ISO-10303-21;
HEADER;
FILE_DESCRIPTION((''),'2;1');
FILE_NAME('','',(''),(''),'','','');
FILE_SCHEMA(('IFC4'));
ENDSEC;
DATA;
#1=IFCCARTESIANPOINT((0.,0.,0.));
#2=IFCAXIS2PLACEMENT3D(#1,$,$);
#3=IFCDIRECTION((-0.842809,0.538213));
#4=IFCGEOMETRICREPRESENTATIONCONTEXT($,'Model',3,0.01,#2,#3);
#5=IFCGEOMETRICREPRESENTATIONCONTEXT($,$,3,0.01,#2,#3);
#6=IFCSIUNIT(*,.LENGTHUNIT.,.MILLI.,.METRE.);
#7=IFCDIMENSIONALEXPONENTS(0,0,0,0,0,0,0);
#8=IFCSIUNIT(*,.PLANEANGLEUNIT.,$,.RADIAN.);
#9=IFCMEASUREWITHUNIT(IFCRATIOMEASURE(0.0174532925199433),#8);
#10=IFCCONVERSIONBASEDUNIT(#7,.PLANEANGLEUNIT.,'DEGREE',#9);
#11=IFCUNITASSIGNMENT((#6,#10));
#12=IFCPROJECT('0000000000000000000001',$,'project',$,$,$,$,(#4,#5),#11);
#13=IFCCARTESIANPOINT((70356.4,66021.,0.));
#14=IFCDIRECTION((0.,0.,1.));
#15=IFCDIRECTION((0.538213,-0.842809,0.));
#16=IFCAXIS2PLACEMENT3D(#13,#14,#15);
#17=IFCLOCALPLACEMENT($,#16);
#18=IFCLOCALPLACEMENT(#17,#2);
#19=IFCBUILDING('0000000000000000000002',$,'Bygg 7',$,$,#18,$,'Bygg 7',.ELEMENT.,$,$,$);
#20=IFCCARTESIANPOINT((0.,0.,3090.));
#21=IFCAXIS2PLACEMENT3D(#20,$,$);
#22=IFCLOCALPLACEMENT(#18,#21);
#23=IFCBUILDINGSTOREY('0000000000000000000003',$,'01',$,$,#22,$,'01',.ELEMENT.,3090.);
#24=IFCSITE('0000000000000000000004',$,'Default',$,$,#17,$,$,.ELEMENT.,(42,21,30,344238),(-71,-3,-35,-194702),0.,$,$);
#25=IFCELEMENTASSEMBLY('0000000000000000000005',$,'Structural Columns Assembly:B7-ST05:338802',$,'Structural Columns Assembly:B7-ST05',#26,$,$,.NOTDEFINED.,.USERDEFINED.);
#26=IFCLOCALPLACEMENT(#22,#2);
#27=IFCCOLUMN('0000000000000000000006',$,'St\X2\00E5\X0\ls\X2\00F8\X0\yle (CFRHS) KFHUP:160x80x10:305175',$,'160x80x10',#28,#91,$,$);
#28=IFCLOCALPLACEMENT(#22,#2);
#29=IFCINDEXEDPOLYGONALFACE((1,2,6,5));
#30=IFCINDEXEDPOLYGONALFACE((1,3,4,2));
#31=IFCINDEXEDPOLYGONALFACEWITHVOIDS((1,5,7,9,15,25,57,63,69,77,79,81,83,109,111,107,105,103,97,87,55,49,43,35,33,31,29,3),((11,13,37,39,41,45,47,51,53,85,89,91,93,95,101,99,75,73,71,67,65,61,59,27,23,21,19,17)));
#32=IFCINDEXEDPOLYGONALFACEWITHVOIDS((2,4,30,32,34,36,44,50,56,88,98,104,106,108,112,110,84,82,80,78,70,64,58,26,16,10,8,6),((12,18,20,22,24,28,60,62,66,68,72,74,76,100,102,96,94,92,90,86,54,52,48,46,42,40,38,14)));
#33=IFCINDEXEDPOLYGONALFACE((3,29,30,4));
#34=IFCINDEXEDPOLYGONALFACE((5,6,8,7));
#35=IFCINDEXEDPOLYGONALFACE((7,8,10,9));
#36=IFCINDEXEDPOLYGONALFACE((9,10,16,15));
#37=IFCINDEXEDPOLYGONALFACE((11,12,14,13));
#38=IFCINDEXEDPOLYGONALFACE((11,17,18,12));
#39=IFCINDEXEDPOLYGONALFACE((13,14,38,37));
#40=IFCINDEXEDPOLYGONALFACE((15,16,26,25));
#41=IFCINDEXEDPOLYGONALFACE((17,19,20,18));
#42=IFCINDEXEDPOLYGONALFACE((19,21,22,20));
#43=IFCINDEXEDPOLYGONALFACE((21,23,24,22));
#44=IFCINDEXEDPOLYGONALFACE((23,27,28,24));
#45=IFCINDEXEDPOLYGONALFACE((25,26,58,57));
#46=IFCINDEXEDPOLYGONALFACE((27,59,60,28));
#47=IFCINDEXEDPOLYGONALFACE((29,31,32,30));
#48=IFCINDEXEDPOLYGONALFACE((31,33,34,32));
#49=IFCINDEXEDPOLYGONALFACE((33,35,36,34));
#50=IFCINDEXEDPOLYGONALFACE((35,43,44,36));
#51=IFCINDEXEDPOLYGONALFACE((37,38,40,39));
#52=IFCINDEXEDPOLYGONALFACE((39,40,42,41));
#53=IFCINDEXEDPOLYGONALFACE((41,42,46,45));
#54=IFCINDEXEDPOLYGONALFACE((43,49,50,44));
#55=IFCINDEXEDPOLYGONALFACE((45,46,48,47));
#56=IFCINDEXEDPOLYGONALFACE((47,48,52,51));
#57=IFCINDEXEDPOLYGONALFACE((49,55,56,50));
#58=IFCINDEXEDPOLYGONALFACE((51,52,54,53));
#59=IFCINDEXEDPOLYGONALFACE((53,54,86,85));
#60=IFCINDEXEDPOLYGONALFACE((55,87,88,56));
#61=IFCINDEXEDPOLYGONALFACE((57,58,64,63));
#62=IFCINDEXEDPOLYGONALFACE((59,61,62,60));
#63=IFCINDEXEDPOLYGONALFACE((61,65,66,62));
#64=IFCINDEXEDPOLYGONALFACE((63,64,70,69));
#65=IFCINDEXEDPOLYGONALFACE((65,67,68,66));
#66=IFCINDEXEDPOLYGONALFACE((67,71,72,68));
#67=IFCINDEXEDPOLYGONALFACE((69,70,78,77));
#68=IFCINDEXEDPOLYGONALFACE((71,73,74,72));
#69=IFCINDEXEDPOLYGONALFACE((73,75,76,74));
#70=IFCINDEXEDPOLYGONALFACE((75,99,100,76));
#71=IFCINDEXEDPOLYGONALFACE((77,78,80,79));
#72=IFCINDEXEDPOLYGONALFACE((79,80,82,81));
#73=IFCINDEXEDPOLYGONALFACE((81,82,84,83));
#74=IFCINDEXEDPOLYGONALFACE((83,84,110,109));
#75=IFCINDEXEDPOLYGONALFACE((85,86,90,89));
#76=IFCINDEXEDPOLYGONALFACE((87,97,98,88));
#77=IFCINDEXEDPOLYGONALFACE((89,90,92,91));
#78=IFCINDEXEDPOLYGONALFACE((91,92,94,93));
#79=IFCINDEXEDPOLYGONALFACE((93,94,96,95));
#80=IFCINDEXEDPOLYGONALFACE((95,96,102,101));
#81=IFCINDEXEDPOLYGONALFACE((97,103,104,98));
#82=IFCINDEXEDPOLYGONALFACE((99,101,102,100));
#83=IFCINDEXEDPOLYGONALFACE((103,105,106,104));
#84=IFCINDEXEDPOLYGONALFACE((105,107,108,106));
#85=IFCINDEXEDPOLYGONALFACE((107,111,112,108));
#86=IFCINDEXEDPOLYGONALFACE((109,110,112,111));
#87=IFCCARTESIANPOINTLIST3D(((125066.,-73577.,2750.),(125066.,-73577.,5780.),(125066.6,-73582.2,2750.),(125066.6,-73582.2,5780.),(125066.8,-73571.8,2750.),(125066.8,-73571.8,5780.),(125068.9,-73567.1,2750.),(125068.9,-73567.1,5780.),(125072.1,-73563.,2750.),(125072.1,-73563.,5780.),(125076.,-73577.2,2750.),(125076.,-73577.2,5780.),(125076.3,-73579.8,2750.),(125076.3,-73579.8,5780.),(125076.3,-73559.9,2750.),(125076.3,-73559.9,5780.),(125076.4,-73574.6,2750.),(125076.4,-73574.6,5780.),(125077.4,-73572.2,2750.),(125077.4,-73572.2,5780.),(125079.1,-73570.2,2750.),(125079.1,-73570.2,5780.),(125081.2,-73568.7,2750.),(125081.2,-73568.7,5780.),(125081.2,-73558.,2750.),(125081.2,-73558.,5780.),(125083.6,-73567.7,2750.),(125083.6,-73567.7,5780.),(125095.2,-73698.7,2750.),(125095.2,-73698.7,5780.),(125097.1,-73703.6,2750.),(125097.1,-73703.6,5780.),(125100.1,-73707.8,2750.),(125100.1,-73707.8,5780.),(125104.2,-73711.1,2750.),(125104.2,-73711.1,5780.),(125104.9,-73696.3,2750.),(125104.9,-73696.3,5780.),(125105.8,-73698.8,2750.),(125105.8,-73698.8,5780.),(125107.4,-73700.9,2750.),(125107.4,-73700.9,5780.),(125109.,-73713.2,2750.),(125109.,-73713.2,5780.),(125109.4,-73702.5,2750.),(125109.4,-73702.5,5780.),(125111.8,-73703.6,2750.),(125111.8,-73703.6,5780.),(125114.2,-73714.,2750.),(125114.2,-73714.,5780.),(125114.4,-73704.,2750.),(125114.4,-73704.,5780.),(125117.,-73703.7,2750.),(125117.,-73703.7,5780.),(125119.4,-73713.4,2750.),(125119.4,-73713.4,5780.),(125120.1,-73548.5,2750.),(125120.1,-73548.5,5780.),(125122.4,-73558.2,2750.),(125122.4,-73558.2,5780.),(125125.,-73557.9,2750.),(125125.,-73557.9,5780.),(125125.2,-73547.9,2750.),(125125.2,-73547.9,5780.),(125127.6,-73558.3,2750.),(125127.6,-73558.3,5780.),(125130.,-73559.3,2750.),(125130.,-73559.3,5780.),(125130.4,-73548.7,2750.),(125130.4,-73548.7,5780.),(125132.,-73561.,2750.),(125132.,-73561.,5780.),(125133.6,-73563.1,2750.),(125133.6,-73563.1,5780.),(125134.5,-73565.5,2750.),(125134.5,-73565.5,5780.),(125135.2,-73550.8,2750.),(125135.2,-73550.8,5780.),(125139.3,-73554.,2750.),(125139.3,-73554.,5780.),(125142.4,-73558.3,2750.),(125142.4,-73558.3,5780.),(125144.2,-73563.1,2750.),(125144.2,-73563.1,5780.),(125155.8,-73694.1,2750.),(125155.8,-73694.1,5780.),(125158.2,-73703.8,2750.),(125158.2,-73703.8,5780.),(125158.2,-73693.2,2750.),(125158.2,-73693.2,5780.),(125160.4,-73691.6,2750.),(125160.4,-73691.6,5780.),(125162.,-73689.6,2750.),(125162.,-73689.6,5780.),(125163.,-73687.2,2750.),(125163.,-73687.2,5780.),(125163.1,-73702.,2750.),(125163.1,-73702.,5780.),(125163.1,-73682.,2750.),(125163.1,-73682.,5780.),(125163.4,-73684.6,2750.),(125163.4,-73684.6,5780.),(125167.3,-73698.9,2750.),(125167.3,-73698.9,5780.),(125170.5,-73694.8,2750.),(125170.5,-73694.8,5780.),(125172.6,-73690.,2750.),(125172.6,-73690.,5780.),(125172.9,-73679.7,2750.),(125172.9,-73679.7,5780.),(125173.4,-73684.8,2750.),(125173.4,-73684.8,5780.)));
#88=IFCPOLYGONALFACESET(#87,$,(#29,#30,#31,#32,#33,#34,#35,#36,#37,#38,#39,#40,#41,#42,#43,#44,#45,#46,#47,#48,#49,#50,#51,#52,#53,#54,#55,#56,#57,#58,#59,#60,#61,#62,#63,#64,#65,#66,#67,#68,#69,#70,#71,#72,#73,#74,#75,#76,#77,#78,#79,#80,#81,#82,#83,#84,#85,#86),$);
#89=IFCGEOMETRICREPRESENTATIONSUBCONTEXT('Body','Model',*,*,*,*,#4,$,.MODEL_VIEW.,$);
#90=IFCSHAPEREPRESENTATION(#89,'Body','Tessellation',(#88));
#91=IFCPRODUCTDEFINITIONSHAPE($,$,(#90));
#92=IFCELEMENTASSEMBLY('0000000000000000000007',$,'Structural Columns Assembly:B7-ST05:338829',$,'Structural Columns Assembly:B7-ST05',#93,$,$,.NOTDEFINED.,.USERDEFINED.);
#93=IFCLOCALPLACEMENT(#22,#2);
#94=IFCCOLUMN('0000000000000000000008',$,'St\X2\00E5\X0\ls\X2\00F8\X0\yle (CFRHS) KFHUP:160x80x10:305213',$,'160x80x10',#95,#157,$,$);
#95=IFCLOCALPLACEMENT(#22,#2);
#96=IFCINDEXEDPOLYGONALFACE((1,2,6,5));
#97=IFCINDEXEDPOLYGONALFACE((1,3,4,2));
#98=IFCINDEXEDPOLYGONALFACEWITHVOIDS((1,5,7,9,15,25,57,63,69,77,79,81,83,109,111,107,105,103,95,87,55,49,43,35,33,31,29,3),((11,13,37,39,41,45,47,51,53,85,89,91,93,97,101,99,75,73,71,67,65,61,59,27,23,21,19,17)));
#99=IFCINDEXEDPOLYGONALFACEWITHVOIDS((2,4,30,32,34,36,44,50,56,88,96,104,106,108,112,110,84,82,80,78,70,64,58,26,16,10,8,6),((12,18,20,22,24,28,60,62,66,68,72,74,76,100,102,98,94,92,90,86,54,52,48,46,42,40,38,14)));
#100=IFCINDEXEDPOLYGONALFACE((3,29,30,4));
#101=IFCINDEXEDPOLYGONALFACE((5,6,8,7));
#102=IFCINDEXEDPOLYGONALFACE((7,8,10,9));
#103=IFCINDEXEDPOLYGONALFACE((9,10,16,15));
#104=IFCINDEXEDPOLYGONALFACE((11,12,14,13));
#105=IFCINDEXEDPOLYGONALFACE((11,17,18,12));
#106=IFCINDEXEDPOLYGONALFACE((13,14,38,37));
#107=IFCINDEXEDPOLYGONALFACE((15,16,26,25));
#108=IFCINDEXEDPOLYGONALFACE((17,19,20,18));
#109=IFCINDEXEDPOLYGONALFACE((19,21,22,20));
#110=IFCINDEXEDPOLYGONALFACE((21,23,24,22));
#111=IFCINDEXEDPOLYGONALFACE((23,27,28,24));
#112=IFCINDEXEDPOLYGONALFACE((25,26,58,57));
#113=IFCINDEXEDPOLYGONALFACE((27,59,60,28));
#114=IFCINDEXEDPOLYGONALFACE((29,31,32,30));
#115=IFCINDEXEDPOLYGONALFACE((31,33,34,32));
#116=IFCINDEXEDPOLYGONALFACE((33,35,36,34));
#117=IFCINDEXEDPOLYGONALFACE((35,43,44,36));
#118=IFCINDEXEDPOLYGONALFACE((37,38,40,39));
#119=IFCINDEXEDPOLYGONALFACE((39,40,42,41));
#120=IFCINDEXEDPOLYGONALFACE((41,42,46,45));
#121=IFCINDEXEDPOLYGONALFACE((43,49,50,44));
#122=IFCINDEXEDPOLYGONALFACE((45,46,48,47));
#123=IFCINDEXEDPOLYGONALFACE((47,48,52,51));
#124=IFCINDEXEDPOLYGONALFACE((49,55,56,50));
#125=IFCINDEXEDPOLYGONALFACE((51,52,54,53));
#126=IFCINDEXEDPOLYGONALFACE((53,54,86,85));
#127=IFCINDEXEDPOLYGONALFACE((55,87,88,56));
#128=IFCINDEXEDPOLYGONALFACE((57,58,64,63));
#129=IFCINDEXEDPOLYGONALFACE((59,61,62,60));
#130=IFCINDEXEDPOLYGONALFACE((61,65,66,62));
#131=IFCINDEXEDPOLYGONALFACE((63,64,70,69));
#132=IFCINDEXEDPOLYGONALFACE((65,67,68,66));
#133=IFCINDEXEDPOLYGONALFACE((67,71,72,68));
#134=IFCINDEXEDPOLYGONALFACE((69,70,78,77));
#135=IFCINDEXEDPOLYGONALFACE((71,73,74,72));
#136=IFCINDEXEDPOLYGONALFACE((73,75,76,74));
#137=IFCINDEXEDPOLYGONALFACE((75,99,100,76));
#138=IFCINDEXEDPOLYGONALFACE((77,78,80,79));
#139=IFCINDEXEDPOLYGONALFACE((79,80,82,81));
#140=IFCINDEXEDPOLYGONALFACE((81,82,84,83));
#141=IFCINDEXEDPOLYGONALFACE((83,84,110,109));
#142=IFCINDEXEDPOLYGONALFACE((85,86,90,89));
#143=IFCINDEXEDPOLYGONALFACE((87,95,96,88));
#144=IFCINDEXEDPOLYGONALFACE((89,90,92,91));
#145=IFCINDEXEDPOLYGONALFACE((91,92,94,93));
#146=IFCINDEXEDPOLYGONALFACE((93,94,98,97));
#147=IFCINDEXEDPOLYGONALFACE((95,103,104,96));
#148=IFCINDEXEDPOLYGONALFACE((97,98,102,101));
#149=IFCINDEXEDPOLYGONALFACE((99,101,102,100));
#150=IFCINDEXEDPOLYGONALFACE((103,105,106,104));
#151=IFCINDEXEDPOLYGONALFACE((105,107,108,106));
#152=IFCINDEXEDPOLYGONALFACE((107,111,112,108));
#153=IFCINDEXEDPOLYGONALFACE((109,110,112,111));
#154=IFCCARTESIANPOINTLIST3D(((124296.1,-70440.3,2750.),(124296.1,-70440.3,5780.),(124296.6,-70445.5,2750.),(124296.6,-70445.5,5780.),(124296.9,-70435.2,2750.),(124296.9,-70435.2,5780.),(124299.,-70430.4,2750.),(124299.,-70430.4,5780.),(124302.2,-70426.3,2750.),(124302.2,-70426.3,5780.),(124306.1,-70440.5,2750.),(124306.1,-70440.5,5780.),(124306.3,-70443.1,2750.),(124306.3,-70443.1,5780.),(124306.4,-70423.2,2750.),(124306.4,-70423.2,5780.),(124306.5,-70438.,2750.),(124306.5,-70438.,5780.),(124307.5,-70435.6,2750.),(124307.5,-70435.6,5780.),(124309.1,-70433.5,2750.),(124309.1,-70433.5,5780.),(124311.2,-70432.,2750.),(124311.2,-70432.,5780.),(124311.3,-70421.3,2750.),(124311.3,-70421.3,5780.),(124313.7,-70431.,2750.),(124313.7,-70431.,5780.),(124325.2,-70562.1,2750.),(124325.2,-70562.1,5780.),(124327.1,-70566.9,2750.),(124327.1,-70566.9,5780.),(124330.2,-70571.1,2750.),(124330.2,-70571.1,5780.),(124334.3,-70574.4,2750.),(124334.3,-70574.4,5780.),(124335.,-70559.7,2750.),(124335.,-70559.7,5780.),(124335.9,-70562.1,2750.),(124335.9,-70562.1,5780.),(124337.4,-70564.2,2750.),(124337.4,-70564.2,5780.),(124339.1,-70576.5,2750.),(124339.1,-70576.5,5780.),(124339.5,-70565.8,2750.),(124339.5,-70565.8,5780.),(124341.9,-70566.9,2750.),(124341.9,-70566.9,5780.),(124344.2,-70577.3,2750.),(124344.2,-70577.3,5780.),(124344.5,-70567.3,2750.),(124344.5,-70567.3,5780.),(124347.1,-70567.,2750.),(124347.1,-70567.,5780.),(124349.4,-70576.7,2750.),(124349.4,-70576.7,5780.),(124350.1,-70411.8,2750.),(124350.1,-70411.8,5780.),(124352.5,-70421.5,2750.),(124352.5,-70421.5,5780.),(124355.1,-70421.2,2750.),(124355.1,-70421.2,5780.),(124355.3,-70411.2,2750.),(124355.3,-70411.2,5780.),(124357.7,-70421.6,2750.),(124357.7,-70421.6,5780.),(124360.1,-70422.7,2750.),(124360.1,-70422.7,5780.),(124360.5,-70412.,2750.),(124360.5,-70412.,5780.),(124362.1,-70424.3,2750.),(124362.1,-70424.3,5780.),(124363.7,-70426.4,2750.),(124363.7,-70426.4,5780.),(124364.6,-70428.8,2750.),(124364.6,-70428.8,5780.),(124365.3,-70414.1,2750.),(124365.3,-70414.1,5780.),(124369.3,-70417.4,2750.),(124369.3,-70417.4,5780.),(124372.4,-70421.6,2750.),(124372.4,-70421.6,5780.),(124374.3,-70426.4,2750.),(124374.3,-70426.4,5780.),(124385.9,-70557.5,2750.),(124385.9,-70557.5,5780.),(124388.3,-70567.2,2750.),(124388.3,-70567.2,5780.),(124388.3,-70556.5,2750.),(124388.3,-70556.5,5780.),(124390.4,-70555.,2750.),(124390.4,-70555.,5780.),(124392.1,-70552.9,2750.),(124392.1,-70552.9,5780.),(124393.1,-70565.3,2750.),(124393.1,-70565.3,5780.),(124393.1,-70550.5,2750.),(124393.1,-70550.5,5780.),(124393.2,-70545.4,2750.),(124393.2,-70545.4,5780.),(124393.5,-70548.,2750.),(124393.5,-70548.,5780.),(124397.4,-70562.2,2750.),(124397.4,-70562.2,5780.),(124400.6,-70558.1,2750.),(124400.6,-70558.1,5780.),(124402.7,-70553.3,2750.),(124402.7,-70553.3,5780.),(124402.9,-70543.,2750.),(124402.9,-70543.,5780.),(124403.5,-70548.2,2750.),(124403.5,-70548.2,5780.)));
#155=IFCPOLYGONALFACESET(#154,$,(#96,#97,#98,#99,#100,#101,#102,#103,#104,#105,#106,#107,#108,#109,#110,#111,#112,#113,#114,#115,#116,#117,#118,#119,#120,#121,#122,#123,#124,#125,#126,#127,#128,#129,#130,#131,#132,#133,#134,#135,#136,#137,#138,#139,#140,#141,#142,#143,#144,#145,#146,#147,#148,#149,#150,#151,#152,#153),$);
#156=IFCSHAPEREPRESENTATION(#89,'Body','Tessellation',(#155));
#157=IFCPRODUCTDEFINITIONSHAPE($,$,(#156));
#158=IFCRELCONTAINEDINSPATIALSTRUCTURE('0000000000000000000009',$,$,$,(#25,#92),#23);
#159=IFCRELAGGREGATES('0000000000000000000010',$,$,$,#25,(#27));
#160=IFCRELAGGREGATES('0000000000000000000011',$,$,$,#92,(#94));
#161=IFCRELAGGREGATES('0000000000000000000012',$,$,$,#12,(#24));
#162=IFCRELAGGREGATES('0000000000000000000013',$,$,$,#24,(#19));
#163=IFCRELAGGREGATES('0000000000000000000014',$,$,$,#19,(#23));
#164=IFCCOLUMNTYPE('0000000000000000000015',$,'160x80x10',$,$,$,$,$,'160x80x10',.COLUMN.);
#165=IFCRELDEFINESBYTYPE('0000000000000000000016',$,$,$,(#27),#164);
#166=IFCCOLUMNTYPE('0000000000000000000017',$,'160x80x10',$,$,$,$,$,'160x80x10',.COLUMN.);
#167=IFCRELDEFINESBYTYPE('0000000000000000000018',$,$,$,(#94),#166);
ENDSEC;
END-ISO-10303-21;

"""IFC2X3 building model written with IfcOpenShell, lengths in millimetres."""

from ifc_helpers import new_model, entity, si_unit, converted_unit, direction, frame, frame_2d, origin, place, context, subcontext, project, spatial, polyline, circle_curve, parameter, trimmed, segment, composite_curve, outline, extrude, source, transform, mapped, type_object, type_shapes, element, aggregate, save


model = new_model("IFC2X3")

# Units and contexts
model_context = context("Model", 3, precision=0.01, world=origin(), true_north=direction((-0.842809, 0.538213)))
context_of_model = context(None, 3, precision=0.01, world=origin(), true_north=direction((-0.842809, 0.538213)))
body_context = subcontext(model_context, "Body", "Model", "MODEL_VIEW")
ifc_project = project(units=[si_unit("LENGTHUNIT", "METRE", prefix="MILLI"), converted_unit("PLANEANGLEUNIT", "DEGREE", entity("IfcRatioMeasure", 0.0174532925199433), si_unit("PLANEANGLEUNIT", "RADIAN"), dimensions=[0, 0, 0, 0, 0, 0, 0])], contexts=[model_context, context_of_model])

# Site, building, storey
site_placement = place(None, frame((70356.4, 66021.0, 0.0), z_axis=(0.0, 0.0, 1.0), x_axis=(0.538213, -0.842809, 0.0)))
site = spatial("IfcSite", under=ifc_project, at=site_placement, Name="Default", CompositionType="ELEMENT", RefLatitude=(42, 21, 30, 344238), RefLongitude=(-71, -3, -35, -194702), RefElevation=0.0)
building_placement = place(site_placement, origin())
building = spatial("IfcBuilding", under=site, at=building_placement, Name="Bygg 7", LongName="Bygg 7", CompositionType="ELEMENT")
storey_placement = place(building_placement, frame((0.0, 0.0, 3090.0)))
storey = spatial("IfcBuildingStorey", under=building, at=storey_placement, Name="01", LongName="01", CompositionType="ELEMENT", Elevation=3090.0)

# Element assemblies, columns
assembly_1_placement = place(storey_placement, origin())
assembly_1 = element("IfcElementAssembly", 1, at=assembly_1_placement, inside=storey, Name="Structural Columns Assembly:B7-ST05:338802", ObjectType="Structural Columns Assembly:B7-ST05", AssemblyPlace="NOTDEFINED", PredefinedType="USERDEFINED")
column_type_1 = type_object("IfcColumnType", Name="160x80x10", ElementType="160x80x10", PredefinedType="COLUMN")
shared_shape_1 = source(origin(), body_context, "Body", "SweptSolid", [
    extrude(outline(composite_curve([segment(trimmed(circle_curve(frame_2d((-20.0, 60.0), x_axis=(1.0, 0.0)), 20.0), [parameter(90.0)], [parameter(180.0)], True, "PARAMETER"), True, "CONTINUOUS"), segment(polyline([(-40.0, 60.0), (-40.0, -60.0)]), True, "CONTINUOUS"), segment(trimmed(circle_curve(frame_2d((-20.0, -60.0), x_axis=(1.0, 0.0)), 20.0), [parameter(180.0)], [parameter(270.0)], True, "PARAMETER"), True, "CONTINUOUS"), segment(polyline([(-20.0, -80.0), (20.0, -80.0)]), True, "CONTINUOUS"), segment(trimmed(circle_curve(frame_2d((20.0, -60.0), x_axis=(1.0, 0.0)), 20.0), [parameter(270.0)], [parameter(0.0)], True, "PARAMETER"), True, "CONTINUOUS"), segment(polyline([(40.0, -60.0), (40.0, 60.0)]), True, "CONTINUOUS"), segment(trimmed(circle_curve(frame_2d((20.0, 60.0), x_axis=(1.0, 0.0)), 20.0), [parameter(0.0)], [parameter(90.0)], True, "PARAMETER"), True, "CONTINUOUS"), segment(polyline([(20.0, 80.0), (-20.0, 80.0)]), True, "CONTINUOUS")], self_intersect=False), holes=[composite_curve([segment(polyline([(-20.0, 70.0), (20.0, 70.0)]), True, "CONTINUOUS"), segment(trimmed(circle_curve(frame_2d((20.0, 60.0), x_axis=(1.0, 0.0)), 10.0), [parameter(360.0)], [parameter(90.0)], True, "PARAMETER"), False, "CONTINUOUS"), segment(polyline([(30.0, 60.0), (30.0, -60.0)]), True, "CONTINUOUS"), segment(trimmed(circle_curve(frame_2d((20.0, -60.0), x_axis=(1.0, 0.0)), 10.0), [parameter(270.0)], [parameter(360.0)], True, "PARAMETER"), False, "CONTINUOUS"), segment(polyline([(20.0, -70.0), (-20.0, -70.0)]), True, "CONTINUOUS"), segment(trimmed(circle_curve(frame_2d((-20.0, -60.0), x_axis=(1.0, 0.0)), 10.0), [parameter(180.0)], [parameter(270.0)], True, "PARAMETER"), False, "CONTINUOUS"), segment(polyline([(-30.0, -60.0), (-30.0, 60.0)]), True, "CONTINUOUS"), segment(trimmed(circle_curve(frame_2d((-20.0, 60.0), x_axis=(1.0, 0.0)), 10.0), [parameter(90.0)], [parameter(180.0)], True, "PARAMETER"), False, "CONTINUOUS")], self_intersect=False)]), frame((55.3, 84.6, 0.0), z_axis=(0.0, 0.0, 1.0), x_axis=(-0.971172, -0.238381, 0.0)), (0.0, 0.0, 1.0), 3030.0),
])
type_shapes(column_type_1, [shared_shape_1])
column_1_placement = place(assembly_1_placement, frame((125064.4, -73715.5, 2750.0)))
column_1 = element("IfcColumn", 2, at=column_1_placement, type_object=column_type_1, Name="Stålsøyle (CFRHS) KFHUP:160x80x10:305175", ObjectType="160x80x10", context=body_context, shape_type="MappedRepresentation", body=[
    mapped(shared_shape_1, transform((0.0, 0.0, 0.0), scale=1.0)),
])
aggregate(assembly_1, [column_1])
assembly_2_placement = place(storey_placement, origin())
assembly_2 = element("IfcElementAssembly", 3, at=assembly_2_placement, inside=storey, Name="Structural Columns Assembly:B7-ST05:338829", ObjectType="Structural Columns Assembly:B7-ST05", AssemblyPlace="NOTDEFINED", PredefinedType="USERDEFINED")
column_type_2 = type_object("IfcColumnType", Name="160x80x10", ElementType="160x80x10", PredefinedType="COLUMN")
shared_shape_2 = source(origin(), body_context, "Body", "SweptSolid", [
    extrude(outline(composite_curve([segment(trimmed(circle_curve(frame_2d((-20.0, 60.0), x_axis=(1.0, 0.0)), 20.0), [parameter(90.0)], [parameter(180.0)], True, "PARAMETER"), True, "CONTINUOUS"), segment(polyline([(-40.0, 60.0), (-40.0, -60.0)]), True, "CONTINUOUS"), segment(trimmed(circle_curve(frame_2d((-20.0, -60.0), x_axis=(1.0, 0.0)), 20.0), [parameter(180.0)], [parameter(270.0)], True, "PARAMETER"), True, "CONTINUOUS"), segment(polyline([(-20.0, -80.0), (20.0, -80.0)]), True, "CONTINUOUS"), segment(trimmed(circle_curve(frame_2d((20.0, -60.0), x_axis=(1.0, 0.0)), 20.0), [parameter(270.0)], [parameter(0.0)], True, "PARAMETER"), True, "CONTINUOUS"), segment(polyline([(40.0, -60.0), (40.0, 60.0)]), True, "CONTINUOUS"), segment(trimmed(circle_curve(frame_2d((20.0, 60.0), x_axis=(1.0, 0.0)), 20.0), [parameter(0.0)], [parameter(90.0)], True, "PARAMETER"), True, "CONTINUOUS"), segment(polyline([(20.0, 80.0), (-20.0, 80.0)]), True, "CONTINUOUS")], self_intersect=False), holes=[composite_curve([segment(polyline([(-20.0, 70.0), (20.0, 70.0)]), True, "CONTINUOUS"), segment(trimmed(circle_curve(frame_2d((20.0, 60.0), x_axis=(1.0, 0.0)), 10.0), [parameter(360.0)], [parameter(90.0)], True, "PARAMETER"), False, "CONTINUOUS"), segment(polyline([(30.0, 60.0), (30.0, -60.0)]), True, "CONTINUOUS"), segment(trimmed(circle_curve(frame_2d((20.0, -60.0), x_axis=(1.0, 0.0)), 10.0), [parameter(270.0)], [parameter(360.0)], True, "PARAMETER"), False, "CONTINUOUS"), segment(polyline([(20.0, -70.0), (-20.0, -70.0)]), True, "CONTINUOUS"), segment(trimmed(circle_curve(frame_2d((-20.0, -60.0), x_axis=(1.0, 0.0)), 10.0), [parameter(180.0)], [parameter(270.0)], True, "PARAMETER"), False, "CONTINUOUS"), segment(polyline([(-30.0, -60.0), (-30.0, 60.0)]), True, "CONTINUOUS"), segment(trimmed(circle_curve(frame_2d((-20.0, 60.0), x_axis=(1.0, 0.0)), 10.0), [parameter(90.0)], [parameter(180.0)], True, "PARAMETER"), False, "CONTINUOUS")], self_intersect=False)]), frame((55.3, 84.6, 0.0), z_axis=(0.0, 0.0, 1.0), x_axis=(-0.971172, -0.238381, 0.0)), (0.0, 0.0, 1.0), 3030.0),
])
type_shapes(column_type_2, [shared_shape_2])
column_2_placement = place(assembly_2_placement, frame((124294.5, -70578.9, 2750.0)))
column_2 = element("IfcColumn", 4, at=column_2_placement, type_object=column_type_2, Name="Stålsøyle (CFRHS) KFHUP:160x80x10:305213", ObjectType="160x80x10", context=body_context, shape_type="MappedRepresentation", body=[
    mapped(shared_shape_2, transform((0.0, 0.0, 0.0), scale=1.0)),
])
aggregate(assembly_2, [column_2])

save(model, "model.ifc")
